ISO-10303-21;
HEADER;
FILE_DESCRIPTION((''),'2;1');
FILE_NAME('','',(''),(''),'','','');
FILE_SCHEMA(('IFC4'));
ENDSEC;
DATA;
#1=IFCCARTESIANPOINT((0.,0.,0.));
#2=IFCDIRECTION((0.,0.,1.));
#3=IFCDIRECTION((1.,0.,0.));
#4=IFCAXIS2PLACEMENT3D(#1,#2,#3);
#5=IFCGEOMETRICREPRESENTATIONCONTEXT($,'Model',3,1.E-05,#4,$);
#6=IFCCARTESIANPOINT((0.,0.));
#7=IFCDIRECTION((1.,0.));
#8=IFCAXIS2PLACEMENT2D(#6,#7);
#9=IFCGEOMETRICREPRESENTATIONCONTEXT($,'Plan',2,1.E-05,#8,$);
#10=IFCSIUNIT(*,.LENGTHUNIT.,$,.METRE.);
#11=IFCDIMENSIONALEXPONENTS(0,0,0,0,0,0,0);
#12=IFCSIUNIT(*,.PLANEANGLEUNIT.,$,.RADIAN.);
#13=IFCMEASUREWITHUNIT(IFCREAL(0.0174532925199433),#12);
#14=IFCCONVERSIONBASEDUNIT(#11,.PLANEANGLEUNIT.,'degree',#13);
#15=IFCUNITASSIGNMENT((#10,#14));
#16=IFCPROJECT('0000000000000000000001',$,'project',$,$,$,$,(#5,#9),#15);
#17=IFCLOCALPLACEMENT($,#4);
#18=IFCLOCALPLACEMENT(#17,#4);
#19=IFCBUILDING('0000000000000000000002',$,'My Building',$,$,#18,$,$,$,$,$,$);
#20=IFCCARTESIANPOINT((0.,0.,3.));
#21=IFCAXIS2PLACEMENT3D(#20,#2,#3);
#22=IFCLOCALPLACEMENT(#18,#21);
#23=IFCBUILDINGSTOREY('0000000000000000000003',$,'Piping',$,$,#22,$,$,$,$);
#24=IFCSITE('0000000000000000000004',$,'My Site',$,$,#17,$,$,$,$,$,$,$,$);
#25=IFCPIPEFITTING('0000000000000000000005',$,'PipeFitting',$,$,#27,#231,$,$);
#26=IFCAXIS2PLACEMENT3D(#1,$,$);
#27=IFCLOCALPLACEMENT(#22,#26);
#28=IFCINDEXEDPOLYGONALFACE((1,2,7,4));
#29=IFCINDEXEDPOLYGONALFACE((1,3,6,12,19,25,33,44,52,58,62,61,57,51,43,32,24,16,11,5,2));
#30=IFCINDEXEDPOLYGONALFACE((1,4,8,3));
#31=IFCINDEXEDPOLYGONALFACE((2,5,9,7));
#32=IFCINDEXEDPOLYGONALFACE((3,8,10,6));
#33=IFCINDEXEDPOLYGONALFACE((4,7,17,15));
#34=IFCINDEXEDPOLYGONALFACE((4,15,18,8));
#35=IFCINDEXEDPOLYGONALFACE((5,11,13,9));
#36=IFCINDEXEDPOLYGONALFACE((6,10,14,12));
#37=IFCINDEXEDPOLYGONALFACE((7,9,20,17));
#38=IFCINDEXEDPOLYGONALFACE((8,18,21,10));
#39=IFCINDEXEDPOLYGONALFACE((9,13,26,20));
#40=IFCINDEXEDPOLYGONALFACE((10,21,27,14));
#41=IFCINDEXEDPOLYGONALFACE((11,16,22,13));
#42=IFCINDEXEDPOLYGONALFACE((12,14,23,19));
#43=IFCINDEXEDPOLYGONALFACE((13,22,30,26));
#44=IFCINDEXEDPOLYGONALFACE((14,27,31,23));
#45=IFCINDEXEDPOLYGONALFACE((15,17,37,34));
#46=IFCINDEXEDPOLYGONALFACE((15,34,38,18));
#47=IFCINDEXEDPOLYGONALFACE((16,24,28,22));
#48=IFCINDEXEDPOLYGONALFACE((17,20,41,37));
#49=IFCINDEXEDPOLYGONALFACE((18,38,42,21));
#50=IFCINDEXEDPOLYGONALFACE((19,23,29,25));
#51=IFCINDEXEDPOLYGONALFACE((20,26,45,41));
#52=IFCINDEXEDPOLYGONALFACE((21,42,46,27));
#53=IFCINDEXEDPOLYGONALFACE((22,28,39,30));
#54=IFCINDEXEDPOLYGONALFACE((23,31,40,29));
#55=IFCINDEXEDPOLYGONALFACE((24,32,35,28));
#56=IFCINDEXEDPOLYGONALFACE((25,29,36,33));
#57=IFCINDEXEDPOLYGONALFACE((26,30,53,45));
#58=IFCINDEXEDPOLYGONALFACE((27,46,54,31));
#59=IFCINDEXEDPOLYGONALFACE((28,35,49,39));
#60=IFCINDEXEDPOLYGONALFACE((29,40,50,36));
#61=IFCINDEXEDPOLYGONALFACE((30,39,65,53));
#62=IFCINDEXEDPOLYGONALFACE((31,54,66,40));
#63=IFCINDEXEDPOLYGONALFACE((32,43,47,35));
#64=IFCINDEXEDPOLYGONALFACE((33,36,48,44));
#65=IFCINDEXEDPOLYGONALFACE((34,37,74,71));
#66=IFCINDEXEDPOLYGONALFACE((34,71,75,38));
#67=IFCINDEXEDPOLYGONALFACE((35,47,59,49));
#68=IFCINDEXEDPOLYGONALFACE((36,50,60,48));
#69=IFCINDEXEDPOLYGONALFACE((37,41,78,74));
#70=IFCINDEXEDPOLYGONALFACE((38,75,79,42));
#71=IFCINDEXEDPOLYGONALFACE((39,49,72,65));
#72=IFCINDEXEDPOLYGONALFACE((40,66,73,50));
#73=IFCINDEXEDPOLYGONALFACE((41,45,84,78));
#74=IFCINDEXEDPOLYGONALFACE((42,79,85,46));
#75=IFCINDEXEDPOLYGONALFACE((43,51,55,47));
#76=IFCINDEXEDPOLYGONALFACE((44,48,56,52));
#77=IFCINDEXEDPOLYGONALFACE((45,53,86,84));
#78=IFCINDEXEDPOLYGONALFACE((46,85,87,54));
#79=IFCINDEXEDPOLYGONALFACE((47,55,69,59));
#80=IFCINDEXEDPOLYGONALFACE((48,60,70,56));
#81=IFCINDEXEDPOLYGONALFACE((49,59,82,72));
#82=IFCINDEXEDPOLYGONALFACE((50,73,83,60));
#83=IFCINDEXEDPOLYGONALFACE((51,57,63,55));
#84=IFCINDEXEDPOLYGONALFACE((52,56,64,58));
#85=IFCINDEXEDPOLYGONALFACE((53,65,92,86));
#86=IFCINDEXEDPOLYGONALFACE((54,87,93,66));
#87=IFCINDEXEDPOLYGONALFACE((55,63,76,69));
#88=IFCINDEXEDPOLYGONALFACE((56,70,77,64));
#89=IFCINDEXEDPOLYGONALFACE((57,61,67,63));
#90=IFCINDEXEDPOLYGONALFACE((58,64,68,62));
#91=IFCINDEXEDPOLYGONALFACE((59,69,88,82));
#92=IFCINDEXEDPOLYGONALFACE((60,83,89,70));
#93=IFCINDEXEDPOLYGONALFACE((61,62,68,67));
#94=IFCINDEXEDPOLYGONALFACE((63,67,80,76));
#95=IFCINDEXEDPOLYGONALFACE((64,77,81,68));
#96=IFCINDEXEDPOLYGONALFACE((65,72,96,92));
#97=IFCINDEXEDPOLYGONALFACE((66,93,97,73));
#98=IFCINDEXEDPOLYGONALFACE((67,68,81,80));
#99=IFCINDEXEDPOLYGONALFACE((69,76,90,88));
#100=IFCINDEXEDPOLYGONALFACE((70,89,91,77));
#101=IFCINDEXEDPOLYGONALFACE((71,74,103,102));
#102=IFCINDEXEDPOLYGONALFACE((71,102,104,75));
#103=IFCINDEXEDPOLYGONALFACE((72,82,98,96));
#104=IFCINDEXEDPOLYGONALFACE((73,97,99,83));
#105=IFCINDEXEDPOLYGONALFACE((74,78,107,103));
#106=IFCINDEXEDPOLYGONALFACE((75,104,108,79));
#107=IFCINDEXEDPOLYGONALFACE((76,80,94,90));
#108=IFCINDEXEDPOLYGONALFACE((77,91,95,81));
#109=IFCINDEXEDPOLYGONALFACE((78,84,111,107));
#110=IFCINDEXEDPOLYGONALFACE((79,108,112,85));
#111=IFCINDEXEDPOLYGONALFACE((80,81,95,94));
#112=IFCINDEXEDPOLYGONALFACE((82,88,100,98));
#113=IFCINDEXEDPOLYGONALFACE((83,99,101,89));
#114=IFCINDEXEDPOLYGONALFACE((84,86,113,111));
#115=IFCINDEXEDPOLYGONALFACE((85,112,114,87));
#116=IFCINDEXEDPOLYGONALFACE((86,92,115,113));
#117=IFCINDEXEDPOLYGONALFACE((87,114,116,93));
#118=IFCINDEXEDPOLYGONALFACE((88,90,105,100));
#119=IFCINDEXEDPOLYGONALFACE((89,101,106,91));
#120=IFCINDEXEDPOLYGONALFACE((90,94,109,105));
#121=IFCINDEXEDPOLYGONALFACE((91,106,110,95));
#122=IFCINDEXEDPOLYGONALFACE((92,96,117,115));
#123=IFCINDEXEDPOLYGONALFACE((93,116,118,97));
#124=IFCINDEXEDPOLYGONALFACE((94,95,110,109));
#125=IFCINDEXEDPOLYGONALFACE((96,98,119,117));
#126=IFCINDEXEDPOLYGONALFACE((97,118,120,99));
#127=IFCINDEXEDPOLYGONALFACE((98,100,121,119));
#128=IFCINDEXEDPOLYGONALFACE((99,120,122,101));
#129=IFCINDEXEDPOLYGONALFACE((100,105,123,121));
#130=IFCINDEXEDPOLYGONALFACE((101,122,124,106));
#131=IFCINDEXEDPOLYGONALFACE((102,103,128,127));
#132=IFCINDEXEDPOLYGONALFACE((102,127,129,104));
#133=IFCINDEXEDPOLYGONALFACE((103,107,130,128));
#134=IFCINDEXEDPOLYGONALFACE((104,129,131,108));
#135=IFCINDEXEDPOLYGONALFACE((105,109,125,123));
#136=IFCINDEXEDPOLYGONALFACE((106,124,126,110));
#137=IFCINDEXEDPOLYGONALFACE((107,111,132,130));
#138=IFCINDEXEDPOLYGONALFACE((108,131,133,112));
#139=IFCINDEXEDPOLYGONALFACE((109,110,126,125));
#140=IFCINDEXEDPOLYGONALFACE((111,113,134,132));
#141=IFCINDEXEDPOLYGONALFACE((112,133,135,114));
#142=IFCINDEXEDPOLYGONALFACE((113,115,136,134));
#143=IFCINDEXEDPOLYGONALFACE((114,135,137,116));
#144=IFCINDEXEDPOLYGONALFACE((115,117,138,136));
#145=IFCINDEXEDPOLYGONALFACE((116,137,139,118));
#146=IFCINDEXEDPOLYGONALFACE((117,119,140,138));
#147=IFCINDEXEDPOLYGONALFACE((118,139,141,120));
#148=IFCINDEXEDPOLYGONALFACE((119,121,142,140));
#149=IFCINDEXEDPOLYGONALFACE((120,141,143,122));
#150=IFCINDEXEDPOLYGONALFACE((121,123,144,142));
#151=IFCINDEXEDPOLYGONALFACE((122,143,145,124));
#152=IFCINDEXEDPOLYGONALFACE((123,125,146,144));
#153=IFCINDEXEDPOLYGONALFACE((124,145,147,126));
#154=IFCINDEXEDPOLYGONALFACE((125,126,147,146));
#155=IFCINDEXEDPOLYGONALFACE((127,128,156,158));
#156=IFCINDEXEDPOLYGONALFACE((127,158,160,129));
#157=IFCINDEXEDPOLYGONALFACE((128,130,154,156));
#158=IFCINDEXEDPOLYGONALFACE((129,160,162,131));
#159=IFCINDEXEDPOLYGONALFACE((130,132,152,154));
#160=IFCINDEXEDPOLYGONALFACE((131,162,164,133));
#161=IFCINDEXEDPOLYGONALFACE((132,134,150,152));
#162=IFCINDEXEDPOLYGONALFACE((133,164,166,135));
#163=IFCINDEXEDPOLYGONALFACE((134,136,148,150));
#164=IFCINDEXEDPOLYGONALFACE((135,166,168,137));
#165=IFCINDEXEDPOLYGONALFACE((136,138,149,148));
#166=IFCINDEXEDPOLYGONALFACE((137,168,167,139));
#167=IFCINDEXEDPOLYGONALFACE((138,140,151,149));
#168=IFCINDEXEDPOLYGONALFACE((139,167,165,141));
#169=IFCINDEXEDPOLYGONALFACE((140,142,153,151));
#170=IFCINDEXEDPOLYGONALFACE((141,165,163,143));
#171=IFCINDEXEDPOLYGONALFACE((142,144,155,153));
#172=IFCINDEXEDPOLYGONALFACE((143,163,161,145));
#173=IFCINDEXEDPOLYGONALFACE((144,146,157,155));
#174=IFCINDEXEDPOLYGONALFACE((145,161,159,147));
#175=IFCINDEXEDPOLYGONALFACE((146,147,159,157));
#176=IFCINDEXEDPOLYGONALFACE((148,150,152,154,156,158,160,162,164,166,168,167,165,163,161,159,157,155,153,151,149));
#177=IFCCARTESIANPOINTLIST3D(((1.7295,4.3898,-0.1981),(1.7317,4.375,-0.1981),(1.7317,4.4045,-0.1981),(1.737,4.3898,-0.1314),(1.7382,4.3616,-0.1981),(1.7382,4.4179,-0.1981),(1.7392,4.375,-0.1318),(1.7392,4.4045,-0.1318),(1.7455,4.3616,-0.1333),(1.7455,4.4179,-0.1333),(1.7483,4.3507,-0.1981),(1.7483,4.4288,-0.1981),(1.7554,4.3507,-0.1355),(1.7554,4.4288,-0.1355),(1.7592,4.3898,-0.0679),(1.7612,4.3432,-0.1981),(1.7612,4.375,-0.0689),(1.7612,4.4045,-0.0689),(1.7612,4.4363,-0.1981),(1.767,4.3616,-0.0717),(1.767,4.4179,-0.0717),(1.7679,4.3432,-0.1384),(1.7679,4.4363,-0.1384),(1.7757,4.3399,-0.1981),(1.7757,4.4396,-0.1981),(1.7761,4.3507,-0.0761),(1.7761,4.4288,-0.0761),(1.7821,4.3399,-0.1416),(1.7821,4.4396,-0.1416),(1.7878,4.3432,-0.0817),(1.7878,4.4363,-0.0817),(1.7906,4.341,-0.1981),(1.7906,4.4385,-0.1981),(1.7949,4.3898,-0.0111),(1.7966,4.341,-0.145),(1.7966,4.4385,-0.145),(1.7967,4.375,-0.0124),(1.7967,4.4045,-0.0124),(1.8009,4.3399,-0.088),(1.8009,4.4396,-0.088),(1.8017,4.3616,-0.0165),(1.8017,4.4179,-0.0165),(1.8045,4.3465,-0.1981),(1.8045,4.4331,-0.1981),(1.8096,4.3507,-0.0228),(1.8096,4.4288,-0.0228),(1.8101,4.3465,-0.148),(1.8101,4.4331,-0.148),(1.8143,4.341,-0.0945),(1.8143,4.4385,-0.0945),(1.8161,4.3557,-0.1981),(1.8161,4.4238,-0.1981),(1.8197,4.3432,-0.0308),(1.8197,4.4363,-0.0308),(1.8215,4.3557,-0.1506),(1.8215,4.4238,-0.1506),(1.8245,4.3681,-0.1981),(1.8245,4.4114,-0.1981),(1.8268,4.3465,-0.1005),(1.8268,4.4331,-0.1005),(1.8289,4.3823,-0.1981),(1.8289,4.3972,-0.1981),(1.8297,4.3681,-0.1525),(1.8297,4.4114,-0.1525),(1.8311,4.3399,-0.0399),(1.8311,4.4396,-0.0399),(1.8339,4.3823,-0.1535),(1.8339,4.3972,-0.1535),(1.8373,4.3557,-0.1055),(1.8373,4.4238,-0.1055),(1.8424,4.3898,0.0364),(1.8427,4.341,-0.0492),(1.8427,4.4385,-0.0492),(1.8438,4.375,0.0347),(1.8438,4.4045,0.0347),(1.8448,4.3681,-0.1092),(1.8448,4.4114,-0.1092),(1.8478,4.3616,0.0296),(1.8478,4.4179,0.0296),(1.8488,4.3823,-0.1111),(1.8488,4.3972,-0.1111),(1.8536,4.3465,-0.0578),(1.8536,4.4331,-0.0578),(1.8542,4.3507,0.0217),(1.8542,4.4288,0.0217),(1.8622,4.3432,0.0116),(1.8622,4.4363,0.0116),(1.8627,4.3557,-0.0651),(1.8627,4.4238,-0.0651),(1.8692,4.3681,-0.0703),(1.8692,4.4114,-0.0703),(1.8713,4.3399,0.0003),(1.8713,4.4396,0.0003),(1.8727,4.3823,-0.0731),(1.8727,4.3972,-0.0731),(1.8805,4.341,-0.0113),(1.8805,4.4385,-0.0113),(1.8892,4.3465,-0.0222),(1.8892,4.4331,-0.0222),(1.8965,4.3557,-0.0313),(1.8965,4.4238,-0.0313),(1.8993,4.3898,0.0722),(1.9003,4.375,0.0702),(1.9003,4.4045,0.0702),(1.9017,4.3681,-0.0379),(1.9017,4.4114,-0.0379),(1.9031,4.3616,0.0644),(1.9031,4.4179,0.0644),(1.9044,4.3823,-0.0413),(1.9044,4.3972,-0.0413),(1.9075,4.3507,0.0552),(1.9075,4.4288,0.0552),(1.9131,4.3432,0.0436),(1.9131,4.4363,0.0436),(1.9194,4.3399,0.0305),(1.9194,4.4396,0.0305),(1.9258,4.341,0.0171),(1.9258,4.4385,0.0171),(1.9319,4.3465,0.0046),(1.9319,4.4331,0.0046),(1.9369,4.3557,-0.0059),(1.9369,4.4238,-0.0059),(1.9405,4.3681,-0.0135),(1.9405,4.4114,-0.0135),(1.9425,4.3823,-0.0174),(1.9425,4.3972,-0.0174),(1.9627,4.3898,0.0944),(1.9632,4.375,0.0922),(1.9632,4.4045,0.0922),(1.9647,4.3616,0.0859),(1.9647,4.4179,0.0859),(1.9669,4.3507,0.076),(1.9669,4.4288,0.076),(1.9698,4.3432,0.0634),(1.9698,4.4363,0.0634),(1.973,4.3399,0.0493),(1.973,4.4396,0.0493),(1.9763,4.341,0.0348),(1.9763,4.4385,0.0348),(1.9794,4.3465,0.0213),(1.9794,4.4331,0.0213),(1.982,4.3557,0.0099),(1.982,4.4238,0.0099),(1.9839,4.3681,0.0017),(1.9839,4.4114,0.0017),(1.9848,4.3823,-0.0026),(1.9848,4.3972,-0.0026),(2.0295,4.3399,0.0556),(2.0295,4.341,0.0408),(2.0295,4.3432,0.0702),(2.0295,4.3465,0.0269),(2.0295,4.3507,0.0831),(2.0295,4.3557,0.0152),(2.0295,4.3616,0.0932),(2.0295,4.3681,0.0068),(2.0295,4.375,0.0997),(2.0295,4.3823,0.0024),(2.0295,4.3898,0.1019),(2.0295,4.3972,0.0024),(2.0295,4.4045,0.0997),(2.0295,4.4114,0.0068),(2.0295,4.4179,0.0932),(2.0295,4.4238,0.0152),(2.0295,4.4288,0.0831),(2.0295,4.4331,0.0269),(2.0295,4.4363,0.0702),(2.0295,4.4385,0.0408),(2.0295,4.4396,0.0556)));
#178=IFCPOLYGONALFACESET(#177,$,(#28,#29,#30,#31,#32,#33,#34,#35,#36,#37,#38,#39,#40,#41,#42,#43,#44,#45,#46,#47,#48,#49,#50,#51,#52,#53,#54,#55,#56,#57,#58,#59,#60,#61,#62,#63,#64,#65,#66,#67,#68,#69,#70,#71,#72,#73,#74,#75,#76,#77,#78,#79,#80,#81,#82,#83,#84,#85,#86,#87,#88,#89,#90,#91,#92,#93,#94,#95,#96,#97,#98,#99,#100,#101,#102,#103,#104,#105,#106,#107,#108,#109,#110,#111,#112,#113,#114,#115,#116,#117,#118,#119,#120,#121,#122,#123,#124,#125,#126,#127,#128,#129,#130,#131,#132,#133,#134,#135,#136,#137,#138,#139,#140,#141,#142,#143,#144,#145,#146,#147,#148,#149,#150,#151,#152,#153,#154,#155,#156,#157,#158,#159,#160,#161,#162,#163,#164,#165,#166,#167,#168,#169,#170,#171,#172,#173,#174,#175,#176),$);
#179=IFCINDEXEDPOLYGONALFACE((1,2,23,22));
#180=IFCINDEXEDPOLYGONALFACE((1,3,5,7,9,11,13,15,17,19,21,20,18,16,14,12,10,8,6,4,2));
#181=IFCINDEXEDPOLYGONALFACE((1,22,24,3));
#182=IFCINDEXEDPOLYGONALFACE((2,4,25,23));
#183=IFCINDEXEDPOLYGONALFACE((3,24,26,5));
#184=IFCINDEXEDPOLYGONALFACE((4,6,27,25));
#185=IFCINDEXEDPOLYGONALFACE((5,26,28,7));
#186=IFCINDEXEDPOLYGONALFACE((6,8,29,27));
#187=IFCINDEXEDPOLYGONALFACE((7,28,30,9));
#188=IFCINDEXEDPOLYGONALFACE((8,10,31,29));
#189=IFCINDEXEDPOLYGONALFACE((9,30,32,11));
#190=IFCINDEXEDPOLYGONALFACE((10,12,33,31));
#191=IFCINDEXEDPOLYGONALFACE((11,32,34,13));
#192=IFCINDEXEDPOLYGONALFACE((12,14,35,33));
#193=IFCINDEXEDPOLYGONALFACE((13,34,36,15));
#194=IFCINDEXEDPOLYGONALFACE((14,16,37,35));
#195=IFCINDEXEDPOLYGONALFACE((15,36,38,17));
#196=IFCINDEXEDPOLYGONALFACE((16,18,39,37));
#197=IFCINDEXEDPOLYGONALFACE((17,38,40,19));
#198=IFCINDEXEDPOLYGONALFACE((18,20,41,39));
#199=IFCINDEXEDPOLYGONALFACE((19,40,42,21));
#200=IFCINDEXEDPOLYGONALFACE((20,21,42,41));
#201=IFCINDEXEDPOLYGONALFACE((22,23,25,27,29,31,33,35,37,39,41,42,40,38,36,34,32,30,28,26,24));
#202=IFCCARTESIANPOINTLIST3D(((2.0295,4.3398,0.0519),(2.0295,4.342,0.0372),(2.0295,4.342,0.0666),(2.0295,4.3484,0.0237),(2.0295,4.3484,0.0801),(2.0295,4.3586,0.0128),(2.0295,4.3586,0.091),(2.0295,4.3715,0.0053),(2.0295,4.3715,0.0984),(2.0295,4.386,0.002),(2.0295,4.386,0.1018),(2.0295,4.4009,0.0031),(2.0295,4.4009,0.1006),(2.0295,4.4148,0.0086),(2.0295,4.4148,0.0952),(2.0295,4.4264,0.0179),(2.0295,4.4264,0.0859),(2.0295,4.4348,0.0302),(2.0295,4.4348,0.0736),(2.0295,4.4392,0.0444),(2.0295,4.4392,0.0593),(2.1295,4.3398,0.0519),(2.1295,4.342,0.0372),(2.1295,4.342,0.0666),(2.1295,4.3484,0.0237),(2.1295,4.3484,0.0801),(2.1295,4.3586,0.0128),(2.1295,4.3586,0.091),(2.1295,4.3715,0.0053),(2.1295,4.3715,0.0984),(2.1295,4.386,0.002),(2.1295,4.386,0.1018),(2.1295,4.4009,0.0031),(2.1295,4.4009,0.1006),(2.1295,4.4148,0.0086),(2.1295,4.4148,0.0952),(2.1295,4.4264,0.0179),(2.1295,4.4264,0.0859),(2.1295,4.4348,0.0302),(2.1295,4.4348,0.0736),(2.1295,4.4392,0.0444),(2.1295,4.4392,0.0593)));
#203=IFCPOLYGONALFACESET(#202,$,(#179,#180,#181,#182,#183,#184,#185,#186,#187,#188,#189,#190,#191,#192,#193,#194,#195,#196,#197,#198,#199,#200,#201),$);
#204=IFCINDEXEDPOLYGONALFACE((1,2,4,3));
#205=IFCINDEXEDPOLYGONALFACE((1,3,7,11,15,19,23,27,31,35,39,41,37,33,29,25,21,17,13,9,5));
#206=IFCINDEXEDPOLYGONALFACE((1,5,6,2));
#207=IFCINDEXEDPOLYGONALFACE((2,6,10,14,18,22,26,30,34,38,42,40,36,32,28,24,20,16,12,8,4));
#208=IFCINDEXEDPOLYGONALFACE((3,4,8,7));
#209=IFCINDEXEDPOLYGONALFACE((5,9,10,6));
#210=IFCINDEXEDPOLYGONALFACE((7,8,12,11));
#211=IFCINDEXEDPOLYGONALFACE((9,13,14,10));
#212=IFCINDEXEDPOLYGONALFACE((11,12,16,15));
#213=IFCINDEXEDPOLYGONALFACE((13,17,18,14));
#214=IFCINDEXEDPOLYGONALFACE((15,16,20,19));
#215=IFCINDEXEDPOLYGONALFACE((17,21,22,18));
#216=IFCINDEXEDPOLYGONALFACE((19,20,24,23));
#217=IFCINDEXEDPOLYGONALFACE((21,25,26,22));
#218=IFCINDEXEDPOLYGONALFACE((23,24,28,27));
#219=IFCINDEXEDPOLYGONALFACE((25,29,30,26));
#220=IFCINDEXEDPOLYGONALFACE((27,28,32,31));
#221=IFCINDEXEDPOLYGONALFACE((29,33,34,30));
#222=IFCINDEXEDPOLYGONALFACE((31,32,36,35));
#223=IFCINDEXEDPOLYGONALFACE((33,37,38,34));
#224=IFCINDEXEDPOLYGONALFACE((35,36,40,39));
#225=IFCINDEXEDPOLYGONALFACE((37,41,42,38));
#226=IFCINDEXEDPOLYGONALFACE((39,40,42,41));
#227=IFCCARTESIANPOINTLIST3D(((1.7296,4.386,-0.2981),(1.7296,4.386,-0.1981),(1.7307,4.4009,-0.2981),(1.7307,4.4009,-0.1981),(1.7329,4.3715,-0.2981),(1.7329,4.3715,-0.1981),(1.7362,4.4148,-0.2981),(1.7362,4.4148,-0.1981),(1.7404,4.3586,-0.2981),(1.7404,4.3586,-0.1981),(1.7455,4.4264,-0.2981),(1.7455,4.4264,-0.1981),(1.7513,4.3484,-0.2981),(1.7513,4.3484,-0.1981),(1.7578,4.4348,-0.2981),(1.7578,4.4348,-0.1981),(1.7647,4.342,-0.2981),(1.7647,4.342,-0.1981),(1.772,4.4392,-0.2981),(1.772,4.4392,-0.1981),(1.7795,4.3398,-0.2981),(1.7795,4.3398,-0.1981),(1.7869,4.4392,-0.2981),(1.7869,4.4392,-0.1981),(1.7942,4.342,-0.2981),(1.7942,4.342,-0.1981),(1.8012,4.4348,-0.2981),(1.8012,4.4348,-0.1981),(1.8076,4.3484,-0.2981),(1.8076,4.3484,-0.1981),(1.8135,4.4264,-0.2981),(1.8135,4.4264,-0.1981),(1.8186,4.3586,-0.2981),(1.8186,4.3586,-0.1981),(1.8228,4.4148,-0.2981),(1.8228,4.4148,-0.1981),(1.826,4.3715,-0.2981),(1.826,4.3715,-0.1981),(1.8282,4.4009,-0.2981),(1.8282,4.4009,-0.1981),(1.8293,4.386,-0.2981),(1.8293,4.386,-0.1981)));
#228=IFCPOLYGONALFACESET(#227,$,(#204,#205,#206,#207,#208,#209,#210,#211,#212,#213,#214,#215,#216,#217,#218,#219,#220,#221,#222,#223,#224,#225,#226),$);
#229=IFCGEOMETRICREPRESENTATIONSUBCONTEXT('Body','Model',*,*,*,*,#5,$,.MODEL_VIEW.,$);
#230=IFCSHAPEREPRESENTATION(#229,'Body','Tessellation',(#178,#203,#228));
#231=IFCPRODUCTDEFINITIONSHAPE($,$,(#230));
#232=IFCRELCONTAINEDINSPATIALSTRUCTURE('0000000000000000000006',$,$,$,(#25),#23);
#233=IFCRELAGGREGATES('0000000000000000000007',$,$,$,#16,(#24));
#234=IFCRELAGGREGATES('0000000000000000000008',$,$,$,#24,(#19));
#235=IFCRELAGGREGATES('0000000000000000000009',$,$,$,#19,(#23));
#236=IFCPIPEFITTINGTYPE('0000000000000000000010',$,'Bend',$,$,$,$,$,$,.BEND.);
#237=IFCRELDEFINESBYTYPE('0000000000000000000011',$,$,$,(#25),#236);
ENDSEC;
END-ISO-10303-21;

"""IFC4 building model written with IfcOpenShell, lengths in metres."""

from ifc_helpers import new_model, entity, si_unit, converted_unit, frame, origin_with_axes, origin_2d_with_axis, place, context, subcontext, project, spatial, circle, extrude, source, transform, mapped, type_object, type_shapes, element, save


model = new_model("IFC4")

# Units and contexts
model_context = context("Model", 3, precision=1e-05, world=origin_with_axes())
plan_context = context("Plan", 2, precision=1e-05, world=origin_2d_with_axis())
body_context = subcontext(model_context, "Body", "Model", "MODEL_VIEW")
ifc_project = project(units=[si_unit("LENGTHUNIT", "METRE"), converted_unit("PLANEANGLEUNIT", "degree", entity("IfcReal", 0.0174532925199433), si_unit("PLANEANGLEUNIT", "RADIAN"), dimensions=[0, 0, 0, 0, 0, 0, 0])], contexts=[model_context, plan_context])

# Site, building, storey
site_placement = place(None, origin_with_axes())
site = spatial("IfcSite", under=ifc_project, at=site_placement, Name="My Site")
building_placement = place(site_placement, origin_with_axes())
building = spatial("IfcBuilding", under=site, at=building_placement, Name="My Building")
storey_placement = place(building_placement, frame((0.0, 0.0, 3.0), z_axis=(0.0, 0.0, 1.0), x_axis=(1.0, 0.0, 0.0)))
storey = spatial("IfcBuildingStorey", under=building, at=storey_placement, Name="Piping")

# Pipe fitting
pipe_fitting_type_1 = type_object("IfcPipeFittingType", Name="Bend", PredefinedType="BEND")
shared_shape = source(origin_with_axes(), body_context, "Body", "SolidModel", [
    entity("IfcSweptDiskSolid", entity("IfcIndexedPolyCurve", entity("IfcCartesianPointList3D", [[0.0, 0.0, 0.1], [0.0, -0.0732, 0.2768], [0.0, -0.25, 0.35]]), [entity("IfcArcIndex", [1, 2, 3])]), 0.05),
    extrude(circle(Radius=0.05), origin_with_axes(), (0.0, 0.0, 1.0), 0.1),
    extrude(circle(Radius=0.05), frame((0.0, -0.25, 0.35), z_axis=(0.0, -1.0, -0.000001), x_axis=(1.0, 0.0, 0.0)), (0.0, 0.0, 1.0), 0.1),
])
type_shapes(pipe_fitting_type_1, [shared_shape])
for number, where, z_axis, x_axis, name in (
    (1, (2.1295, 4.3898, 0.0519), (-1.0, 0.0, 0.0), (0.0, -1.0, 0.0), "PipeFitting"),
):
    element("IfcPipeFitting", number, at=place(storey_placement, frame(where, z_axis=z_axis, x_axis=x_axis)), inside=storey, type_object=pipe_fitting_type_1, Name=name, context=body_context, shape_type="MappedRepresentation", body=[
        mapped(shared_shape, transform((0.0, 0.0, 0.0), x_axis=(1.0, 0.0, 0.0), y_axis=(0.0, 1.0, 0.0), z_axis=(0.0, 0.0, 1.0), scale=1.0)),
    ])

save(model, "model.ifc")
